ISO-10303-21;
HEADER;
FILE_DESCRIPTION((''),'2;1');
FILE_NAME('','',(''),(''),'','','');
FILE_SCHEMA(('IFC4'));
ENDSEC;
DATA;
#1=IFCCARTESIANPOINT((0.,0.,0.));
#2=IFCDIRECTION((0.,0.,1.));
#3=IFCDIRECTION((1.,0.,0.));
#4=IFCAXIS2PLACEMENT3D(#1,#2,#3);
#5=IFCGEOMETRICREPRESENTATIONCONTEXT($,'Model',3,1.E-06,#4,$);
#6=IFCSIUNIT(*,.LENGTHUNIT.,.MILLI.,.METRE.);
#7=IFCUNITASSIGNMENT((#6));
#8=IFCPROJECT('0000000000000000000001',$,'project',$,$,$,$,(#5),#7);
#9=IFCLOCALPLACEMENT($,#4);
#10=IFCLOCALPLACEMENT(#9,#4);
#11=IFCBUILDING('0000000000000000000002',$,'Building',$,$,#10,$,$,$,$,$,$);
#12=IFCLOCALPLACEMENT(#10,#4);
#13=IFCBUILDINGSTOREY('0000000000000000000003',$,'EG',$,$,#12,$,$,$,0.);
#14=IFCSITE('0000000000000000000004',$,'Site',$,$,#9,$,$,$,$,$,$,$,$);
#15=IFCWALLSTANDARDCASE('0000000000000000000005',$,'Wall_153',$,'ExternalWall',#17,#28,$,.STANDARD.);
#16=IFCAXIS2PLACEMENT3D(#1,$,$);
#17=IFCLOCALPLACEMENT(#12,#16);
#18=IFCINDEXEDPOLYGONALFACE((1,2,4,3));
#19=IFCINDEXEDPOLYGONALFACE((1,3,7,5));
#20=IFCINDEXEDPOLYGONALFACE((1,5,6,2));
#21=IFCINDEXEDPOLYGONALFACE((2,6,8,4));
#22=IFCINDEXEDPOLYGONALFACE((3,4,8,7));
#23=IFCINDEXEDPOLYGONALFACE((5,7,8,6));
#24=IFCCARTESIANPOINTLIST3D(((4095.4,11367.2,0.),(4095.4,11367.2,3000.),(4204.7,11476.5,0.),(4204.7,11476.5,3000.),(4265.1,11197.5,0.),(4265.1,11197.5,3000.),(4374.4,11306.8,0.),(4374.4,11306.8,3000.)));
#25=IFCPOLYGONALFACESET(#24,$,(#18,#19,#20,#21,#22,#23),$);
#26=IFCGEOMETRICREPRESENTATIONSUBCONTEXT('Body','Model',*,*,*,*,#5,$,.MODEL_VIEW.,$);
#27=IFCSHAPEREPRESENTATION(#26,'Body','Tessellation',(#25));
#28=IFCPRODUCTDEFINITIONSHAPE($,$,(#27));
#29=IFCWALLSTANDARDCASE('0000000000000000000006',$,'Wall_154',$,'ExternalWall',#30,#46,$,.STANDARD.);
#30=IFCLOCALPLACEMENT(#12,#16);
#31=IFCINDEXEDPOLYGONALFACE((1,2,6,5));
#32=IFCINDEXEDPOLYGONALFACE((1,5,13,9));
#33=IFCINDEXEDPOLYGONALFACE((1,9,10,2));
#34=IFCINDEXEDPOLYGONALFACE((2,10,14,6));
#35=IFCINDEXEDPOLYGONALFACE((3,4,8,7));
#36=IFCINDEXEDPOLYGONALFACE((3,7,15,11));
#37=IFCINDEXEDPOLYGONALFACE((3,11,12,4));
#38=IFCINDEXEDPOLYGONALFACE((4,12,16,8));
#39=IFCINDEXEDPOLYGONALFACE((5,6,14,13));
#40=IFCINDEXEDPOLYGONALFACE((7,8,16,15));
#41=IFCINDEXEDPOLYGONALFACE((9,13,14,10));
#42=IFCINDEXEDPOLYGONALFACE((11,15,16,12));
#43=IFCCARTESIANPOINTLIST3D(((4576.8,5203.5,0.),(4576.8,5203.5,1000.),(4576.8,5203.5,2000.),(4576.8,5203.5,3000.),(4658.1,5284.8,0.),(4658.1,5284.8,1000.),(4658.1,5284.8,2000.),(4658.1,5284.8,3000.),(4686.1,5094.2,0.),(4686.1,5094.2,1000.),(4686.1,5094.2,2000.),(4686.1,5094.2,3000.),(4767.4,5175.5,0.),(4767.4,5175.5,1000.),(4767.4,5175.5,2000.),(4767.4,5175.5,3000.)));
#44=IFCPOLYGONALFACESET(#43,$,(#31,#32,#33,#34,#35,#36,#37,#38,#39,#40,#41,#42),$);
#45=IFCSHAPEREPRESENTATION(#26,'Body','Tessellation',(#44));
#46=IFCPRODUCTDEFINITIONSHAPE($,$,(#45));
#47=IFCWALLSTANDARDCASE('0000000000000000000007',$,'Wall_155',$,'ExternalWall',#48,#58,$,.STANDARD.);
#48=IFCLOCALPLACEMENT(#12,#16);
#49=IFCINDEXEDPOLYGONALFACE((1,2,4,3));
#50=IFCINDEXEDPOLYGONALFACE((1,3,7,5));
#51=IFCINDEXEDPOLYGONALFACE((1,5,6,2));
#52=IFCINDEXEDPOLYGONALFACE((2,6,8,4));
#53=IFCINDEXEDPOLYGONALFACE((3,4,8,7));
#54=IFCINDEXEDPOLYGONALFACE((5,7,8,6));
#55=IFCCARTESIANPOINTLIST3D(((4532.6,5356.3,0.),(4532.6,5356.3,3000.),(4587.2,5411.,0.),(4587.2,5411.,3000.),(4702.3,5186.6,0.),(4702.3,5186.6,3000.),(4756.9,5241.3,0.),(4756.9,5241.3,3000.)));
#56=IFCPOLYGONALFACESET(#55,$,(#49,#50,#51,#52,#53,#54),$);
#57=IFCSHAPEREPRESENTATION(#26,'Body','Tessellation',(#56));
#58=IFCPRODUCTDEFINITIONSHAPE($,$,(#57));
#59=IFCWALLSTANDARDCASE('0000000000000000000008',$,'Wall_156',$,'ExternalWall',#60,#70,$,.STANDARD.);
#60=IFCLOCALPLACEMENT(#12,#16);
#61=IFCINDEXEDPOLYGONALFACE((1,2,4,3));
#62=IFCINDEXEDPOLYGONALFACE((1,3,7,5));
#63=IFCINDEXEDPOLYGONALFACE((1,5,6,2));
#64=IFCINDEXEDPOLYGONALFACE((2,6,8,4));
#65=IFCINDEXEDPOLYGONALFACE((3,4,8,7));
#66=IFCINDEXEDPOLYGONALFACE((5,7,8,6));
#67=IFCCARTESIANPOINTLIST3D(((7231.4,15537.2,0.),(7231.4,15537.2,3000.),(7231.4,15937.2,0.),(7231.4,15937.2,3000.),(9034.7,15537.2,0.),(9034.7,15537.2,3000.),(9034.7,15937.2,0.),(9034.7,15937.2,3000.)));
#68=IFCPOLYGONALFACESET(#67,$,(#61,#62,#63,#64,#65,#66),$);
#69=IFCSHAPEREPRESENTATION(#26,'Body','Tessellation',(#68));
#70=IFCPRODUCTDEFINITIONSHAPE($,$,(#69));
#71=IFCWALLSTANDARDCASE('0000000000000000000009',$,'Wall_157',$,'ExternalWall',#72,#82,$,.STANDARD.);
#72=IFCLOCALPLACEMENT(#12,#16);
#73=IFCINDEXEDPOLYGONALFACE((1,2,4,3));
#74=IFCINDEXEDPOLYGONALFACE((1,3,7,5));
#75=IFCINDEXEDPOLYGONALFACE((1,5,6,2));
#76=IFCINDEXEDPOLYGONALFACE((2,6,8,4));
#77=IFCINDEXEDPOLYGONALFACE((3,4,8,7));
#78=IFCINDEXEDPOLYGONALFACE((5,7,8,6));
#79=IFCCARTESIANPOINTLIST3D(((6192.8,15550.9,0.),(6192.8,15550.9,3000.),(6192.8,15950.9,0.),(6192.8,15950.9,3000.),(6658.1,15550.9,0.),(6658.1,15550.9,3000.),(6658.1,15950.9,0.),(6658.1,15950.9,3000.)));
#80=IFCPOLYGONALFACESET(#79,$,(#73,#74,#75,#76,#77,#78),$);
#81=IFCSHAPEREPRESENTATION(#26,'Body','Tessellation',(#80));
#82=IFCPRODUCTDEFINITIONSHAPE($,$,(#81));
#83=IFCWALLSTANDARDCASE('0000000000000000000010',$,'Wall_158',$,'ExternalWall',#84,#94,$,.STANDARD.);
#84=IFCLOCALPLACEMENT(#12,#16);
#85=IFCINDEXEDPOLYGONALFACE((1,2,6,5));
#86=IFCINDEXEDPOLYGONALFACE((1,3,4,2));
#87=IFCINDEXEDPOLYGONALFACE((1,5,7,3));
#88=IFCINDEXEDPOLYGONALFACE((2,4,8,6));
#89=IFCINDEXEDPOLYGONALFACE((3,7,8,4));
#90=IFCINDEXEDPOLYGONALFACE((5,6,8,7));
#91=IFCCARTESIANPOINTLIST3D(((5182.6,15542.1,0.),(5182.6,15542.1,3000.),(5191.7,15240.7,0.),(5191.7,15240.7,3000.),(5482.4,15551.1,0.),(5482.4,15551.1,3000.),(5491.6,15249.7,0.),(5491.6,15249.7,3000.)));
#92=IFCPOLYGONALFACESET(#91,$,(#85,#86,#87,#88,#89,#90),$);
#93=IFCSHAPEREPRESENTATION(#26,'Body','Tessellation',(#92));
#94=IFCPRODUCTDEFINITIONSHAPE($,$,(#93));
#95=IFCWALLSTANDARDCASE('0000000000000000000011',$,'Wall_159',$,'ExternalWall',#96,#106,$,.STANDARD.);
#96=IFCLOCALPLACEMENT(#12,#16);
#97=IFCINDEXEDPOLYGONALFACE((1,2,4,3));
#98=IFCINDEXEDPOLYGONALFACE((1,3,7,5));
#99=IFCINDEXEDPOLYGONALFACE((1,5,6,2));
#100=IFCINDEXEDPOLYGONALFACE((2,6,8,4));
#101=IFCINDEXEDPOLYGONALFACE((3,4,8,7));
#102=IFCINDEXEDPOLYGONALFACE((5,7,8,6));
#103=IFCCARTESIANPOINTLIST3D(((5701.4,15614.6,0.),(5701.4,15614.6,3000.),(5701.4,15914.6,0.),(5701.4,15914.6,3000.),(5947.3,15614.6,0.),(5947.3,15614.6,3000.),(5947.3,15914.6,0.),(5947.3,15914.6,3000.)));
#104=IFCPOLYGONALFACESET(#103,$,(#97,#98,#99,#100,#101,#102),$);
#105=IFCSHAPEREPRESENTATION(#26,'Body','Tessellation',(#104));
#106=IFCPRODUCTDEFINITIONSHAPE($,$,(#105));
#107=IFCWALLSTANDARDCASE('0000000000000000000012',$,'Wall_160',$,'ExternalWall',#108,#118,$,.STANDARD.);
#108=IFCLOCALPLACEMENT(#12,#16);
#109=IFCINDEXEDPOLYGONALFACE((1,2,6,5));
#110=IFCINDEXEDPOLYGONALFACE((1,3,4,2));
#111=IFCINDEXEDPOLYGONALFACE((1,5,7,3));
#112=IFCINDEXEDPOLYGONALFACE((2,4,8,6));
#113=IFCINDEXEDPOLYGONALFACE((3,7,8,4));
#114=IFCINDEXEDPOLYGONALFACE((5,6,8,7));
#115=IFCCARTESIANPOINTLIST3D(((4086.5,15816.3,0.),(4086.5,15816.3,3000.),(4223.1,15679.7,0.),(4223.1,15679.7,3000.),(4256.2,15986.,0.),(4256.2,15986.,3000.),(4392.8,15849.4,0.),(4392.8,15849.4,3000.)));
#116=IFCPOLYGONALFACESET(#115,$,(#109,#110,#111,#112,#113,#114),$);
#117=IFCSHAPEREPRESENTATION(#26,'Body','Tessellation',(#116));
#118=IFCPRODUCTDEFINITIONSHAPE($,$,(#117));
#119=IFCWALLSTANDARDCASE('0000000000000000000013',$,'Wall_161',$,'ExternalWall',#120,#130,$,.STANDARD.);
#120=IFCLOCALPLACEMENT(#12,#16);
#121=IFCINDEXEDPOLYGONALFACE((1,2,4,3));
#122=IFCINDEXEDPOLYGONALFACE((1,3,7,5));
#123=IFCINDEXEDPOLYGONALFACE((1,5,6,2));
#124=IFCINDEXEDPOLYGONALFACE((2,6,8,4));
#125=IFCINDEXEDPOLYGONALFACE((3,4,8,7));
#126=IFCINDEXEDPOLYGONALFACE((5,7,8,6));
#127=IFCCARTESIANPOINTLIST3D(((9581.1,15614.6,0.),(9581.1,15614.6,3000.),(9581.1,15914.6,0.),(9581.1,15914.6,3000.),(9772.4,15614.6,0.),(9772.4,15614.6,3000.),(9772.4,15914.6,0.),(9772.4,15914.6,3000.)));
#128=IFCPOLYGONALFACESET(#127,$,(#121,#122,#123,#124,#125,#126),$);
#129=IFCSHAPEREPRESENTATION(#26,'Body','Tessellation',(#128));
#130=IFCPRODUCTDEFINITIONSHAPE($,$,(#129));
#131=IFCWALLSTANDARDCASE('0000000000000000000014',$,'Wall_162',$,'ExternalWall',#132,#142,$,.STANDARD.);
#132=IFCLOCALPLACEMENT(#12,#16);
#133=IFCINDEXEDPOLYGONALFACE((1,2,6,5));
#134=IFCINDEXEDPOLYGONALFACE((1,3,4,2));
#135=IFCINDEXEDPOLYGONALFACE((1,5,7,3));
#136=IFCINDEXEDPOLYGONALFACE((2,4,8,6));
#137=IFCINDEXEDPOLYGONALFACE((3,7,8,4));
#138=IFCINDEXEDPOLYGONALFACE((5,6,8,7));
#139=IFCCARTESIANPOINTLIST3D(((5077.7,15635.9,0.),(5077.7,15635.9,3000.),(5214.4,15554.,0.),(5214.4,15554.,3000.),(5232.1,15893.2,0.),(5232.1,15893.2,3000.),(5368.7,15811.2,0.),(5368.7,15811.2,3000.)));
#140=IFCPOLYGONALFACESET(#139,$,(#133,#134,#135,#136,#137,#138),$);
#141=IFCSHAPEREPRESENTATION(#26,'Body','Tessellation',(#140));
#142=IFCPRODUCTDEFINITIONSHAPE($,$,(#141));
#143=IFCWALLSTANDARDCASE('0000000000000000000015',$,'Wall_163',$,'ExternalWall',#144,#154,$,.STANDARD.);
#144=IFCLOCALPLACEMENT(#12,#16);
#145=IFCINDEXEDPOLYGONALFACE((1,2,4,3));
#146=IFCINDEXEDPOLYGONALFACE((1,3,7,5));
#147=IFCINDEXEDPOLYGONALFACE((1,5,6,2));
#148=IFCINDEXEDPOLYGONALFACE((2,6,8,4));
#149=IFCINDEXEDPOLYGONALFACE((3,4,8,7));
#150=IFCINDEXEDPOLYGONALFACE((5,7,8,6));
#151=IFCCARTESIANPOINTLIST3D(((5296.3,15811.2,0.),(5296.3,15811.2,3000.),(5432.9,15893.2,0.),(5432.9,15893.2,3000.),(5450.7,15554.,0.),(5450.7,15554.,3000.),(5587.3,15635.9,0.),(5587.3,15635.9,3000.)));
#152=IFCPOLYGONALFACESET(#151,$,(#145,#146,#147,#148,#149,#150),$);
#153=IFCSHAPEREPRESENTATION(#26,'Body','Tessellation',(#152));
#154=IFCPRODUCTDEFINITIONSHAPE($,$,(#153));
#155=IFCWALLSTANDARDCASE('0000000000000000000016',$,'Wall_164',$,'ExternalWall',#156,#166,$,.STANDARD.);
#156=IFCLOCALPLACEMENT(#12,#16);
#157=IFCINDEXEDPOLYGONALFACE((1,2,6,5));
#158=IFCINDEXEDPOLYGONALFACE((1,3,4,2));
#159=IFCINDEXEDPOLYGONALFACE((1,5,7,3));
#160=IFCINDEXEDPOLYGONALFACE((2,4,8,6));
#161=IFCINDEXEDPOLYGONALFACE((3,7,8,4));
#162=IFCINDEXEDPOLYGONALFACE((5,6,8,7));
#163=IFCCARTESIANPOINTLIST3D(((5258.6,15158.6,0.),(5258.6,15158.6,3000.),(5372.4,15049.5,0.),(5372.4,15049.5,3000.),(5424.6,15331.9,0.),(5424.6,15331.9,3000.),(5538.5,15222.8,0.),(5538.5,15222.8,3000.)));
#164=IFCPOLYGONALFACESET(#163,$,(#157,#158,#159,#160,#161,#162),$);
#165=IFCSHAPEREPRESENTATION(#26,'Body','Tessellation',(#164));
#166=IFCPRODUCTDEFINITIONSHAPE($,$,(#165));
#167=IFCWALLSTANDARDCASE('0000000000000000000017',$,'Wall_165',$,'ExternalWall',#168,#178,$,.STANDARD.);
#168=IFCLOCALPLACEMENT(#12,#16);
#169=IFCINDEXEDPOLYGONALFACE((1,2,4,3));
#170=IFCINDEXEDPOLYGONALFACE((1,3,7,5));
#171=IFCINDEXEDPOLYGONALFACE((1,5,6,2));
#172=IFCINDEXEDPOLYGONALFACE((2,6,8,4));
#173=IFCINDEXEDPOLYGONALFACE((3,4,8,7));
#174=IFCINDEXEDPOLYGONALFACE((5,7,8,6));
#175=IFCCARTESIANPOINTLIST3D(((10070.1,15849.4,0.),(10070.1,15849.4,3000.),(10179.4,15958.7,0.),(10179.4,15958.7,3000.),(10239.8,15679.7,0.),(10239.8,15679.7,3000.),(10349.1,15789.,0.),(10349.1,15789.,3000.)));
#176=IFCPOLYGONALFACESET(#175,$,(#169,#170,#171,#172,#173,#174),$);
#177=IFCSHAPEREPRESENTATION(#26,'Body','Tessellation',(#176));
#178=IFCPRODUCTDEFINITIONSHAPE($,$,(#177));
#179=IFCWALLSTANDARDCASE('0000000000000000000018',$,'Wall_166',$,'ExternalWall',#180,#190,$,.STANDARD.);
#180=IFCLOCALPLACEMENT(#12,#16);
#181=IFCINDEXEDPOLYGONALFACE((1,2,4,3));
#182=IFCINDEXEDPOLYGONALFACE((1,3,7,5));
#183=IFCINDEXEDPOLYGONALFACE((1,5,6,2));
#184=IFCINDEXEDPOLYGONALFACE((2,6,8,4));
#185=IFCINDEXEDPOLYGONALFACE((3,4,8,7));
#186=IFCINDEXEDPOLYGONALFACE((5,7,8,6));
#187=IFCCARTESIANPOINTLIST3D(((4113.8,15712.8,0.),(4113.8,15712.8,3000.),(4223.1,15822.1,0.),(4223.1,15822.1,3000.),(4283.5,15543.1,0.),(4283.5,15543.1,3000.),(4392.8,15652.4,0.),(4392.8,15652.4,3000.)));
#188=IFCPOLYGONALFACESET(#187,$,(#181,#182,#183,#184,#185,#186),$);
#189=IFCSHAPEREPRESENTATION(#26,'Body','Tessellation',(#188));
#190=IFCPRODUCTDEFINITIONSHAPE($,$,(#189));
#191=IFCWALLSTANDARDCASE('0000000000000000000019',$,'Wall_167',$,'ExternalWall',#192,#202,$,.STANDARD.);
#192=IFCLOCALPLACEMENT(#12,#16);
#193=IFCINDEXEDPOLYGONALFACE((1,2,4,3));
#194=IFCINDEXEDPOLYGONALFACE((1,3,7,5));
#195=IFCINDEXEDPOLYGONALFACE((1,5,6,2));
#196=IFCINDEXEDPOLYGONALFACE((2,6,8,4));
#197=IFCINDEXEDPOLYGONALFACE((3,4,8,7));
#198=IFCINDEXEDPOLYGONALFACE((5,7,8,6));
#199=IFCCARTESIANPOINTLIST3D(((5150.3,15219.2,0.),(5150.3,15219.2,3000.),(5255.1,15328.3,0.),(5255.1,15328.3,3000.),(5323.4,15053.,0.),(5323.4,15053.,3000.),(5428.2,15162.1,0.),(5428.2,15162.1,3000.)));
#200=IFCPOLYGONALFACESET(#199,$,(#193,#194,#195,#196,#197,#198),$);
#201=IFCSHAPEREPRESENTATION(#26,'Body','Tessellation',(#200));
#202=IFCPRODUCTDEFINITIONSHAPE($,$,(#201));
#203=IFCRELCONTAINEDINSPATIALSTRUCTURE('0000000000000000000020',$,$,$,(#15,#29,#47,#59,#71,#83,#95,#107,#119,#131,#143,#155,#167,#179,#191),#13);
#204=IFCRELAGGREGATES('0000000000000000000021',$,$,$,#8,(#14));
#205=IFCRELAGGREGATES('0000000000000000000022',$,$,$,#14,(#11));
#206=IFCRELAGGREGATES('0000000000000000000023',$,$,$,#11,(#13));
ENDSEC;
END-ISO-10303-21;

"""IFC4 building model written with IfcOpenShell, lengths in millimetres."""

from ifc_helpers import new_model, si_unit, frame, origin_with_axes, place, context, subcontext, project, spatial, rectangle, extrude, element, save


model = new_model("IFC4")

# Units and contexts
model_context = context("Model", 3, precision=1e-06, world=origin_with_axes())
body_context = subcontext(model_context, "Body", "Model", "MODEL_VIEW")
ifc_project = project(units=[si_unit("LENGTHUNIT", "METRE", prefix="MILLI")], contexts=[model_context])

# Site, building, storey
site_placement = place(None, origin_with_axes())
site = spatial("IfcSite", under=ifc_project, at=site_placement, Name="Site")
building_placement = place(site_placement, origin_with_axes())
building = spatial("IfcBuilding", under=site, at=building_placement, Name="Building")
storey_placement = place(building_placement, origin_with_axes())
storey = spatial("IfcBuildingStorey", under=building, at=storey_placement, Name="EG", Elevation=0.0)

# Wall
wall_1_placement = place(storey_placement, origin_with_axes())
element("IfcWallStandardCase", 1, at=wall_1_placement, inside=storey, Name="Wall_153", ObjectType="ExternalWall", PredefinedType="STANDARD", context=body_context, shape_type="SweptSolid", body=[
    extrude(rectangle(XDim=154.6, YDim=240.0), frame((4234.9, 11337.0, 0.0), z_axis=(0.0, 0.0, 1.0), x_axis=(0.707107, 0.707107, 0.0)), (0.0, 0.0, 1.0), 3000.0),
])

# Wall, opening
wall_2_placement = place(storey_placement, origin_with_axes())
wall_2 = element("IfcWallStandardCase", 2, at=wall_2_placement, inside=storey, Name="Wall_154", ObjectType="ExternalWall", PredefinedType="STANDARD", context=body_context, shape_type="SweptSolid", body=[
    extrude(rectangle(XDim=154.6, YDim=115.0), frame((4672.1, 5189.5, 0.0), z_axis=(0.0, 0.0, 1.0), x_axis=(0.707107, -0.707107, 0.0)), (0.0, 0.0, 1.0), 3000.0),
])
opening_1_placement = place(wall_2_placement, origin_with_axes())
element("IfcOpeningElement", 3, at=opening_1_placement, inside=storey, cuts=wall_2, context=body_context, shape_type="SweptSolid", body=[
    extrude(rectangle(XDim=2412.3, YDim=115.0), frame((5458.1, 4403.4, 1000.0), z_axis=(0.0, 0.0, 1.0), x_axis=(0.707107, -0.707107, 0.0)), (0.0, 0.0, 1.0), 1000.0),
])

# Walls
wall_3_placement = place(storey_placement, origin_with_axes())
element("IfcWallStandardCase", 4, at=wall_3_placement, inside=storey, Name="Wall_155", ObjectType="ExternalWall", PredefinedType="STANDARD", context=body_context, shape_type="SweptSolid", body=[
    extrude(rectangle(XDim=77.3, YDim=240.0), frame((4644.8, 5298.8, 0.0), z_axis=(0.0, 0.0, 1.0), x_axis=(0.707107, 0.707107, 0.0)), (0.0, 0.0, 1.0), 3000.0),
])
wall_4_placement = place(storey_placement, origin_with_axes())
element("IfcWallStandardCase", 5, at=wall_4_placement, inside=storey, Name="Wall_156", ObjectType="ExternalWall", PredefinedType="STANDARD", context=body_context, shape_type="SweptSolid", body=[
    extrude(rectangle(XDim=1803.3, YDim=400.0), frame((8133.1, 15737.2, 0.0), z_axis=(0.0, 0.0, 1.0), x_axis=(1.0, 0.0, 0.0)), (0.0, 0.0, 1.0), 3000.0),
])
wall_5_placement = place(storey_placement, origin_with_axes())
element("IfcWallStandardCase", 6, at=wall_5_placement, inside=storey, Name="Wall_157", ObjectType="ExternalWall", PredefinedType="STANDARD", context=body_context, shape_type="SweptSolid", body=[
    extrude(rectangle(XDim=465.3, YDim=400.0), frame((6425.4, 15750.9, 0.0), z_axis=(0.0, 0.0, 1.0), x_axis=(1.0, 0.0, 0.0)), (0.0, 0.0, 1.0), 3000.0),
])
wall_6_placement = place(storey_placement, origin_with_axes())
element("IfcWallStandardCase", 7, at=wall_6_placement, inside=storey, Name="Wall_158", ObjectType="ExternalWall", PredefinedType="STANDARD", context=body_context, shape_type="SweptSolid", body=[
    extrude(rectangle(XDim=301.5, YDim=300.0), frame((5337.1, 15395.9, 0.0), z_axis=(0.0, 0.0, 1.0), x_axis=(0.030206, -0.999544, 0.0)), (0.0, 0.0, 1.0), 3000.0),
])
wall_7_placement = place(storey_placement, origin_with_axes())
element("IfcWallStandardCase", 8, at=wall_7_placement, inside=storey, Name="Wall_159", ObjectType="ExternalWall", PredefinedType="STANDARD", context=body_context, shape_type="SweptSolid", body=[
    extrude(rectangle(XDim=245.9, YDim=300.0), frame((5824.3, 15764.6, 0.0), z_axis=(0.0, 0.0, 1.0), x_axis=(1.0, 0.0, 0.0)), (0.0, 0.0, 1.0), 3000.0),
])
wall_8_placement = place(storey_placement, origin_with_axes())
element("IfcWallStandardCase", 9, at=wall_8_placement, inside=storey, Name="Wall_160", ObjectType="ExternalWall", PredefinedType="STANDARD", context=body_context, shape_type="SweptSolid", body=[
    extrude(rectangle(XDim=193.2, YDim=240.0), frame((4239.6, 15832.9, 0.0), z_axis=(0.0, 0.0, 1.0), x_axis=(-0.707107, 0.707107, 0.0)), (0.0, 0.0, 1.0), 3000.0),
])
wall_9_placement = place(storey_placement, origin_with_axes())
element("IfcWallStandardCase", 10, at=wall_9_placement, inside=storey, Name="Wall_161", ObjectType="ExternalWall", PredefinedType="STANDARD", context=body_context, shape_type="SweptSolid", body=[
    extrude(rectangle(XDim=191.3, YDim=300.0), frame((9676.8, 15764.6, 0.0), z_axis=(0.0, 0.0, 1.0), x_axis=(1.0, 0.0, 0.0)), (0.0, 0.0, 1.0), 3000.0),
])
wall_10_placement = place(storey_placement, origin_with_axes())
element("IfcWallStandardCase", 11, at=wall_10_placement, inside=storey, Name="Wall_162", ObjectType="ExternalWall", PredefinedType="STANDARD", context=body_context, shape_type="SweptSolid", body=[
    extrude(rectangle(XDim=159.3, YDim=300.0), frame((5223.2, 15723.6, 0.0), z_axis=(0.0, 0.0, 1.0), x_axis=(0.857493, -0.514496, 0.0)), (0.0, 0.0, 1.0), 3000.0),
])
wall_11_placement = place(storey_placement, origin_with_axes())
element("IfcWallStandardCase", 12, at=wall_11_placement, inside=storey, Name="Wall_163", ObjectType="ExternalWall", PredefinedType="STANDARD", context=body_context, shape_type="SweptSolid", body=[
    extrude(rectangle(XDim=159.3, YDim=300.0), frame((5441.8, 15723.6, 0.0), z_axis=(0.0, 0.0, 1.0), x_axis=(0.857493, 0.514496, 0.0)), (0.0, 0.0, 1.0), 3000.0),
])
wall_12_placement = place(storey_placement, origin_with_axes())
element("IfcWallStandardCase", 13, at=wall_12_placement, inside=storey, Name="Wall_164", ObjectType="ExternalWall", PredefinedType="STANDARD", context=body_context, shape_type="SweptSolid", body=[
    extrude(rectangle(XDim=157.7, YDim=240.0), frame((5398.5, 15190.7, 0.0), z_axis=(0.0, 0.0, 1.0), x_axis=(0.722042, -0.69185, 0.0)), (0.0, 0.0, 1.0), 3000.0),
])
wall_13_placement = place(storey_placement, origin_with_axes())
element("IfcWallStandardCase", 14, at=wall_13_placement, inside=storey, Name="Wall_165", ObjectType="ExternalWall", PredefinedType="STANDARD", context=body_context, shape_type="SweptSolid", body=[
    extrude(rectangle(XDim=154.6, YDim=240.0), frame((10209.6, 15819.2, 0.0), z_axis=(0.0, 0.0, 1.0), x_axis=(0.707107, 0.707107, 0.0)), (0.0, 0.0, 1.0), 3000.0),
])
wall_14_placement = place(storey_placement, origin_with_axes())
element("IfcWallStandardCase", 15, at=wall_14_placement, inside=storey, Name="Wall_166", ObjectType="ExternalWall", PredefinedType="STANDARD", context=body_context, shape_type="SweptSolid", body=[
    extrude(rectangle(XDim=154.6, YDim=240.0), frame((4253.3, 15682.6, 0.0), z_axis=(0.0, 0.0, 1.0), x_axis=(-0.707107, -0.707107, 0.0)), (0.0, 0.0, 1.0), 3000.0),
])
wall_15_placement = place(storey_placement, origin_with_axes())
element("IfcWallStandardCase", 16, at=wall_15_placement, inside=storey, Name="Wall_167", ObjectType="ExternalWall", PredefinedType="STANDARD", context=body_context, shape_type="SweptSolid", body=[
    extrude(rectangle(XDim=151.2, YDim=240.0), frame((5289.3, 15190.7, 0.0), z_axis=(0.0, 0.0, 1.0), x_axis=(-0.692587, -0.721334, 0.0)), (0.0, 0.0, 1.0), 3000.0),
])

save(model, "model.ifc")
